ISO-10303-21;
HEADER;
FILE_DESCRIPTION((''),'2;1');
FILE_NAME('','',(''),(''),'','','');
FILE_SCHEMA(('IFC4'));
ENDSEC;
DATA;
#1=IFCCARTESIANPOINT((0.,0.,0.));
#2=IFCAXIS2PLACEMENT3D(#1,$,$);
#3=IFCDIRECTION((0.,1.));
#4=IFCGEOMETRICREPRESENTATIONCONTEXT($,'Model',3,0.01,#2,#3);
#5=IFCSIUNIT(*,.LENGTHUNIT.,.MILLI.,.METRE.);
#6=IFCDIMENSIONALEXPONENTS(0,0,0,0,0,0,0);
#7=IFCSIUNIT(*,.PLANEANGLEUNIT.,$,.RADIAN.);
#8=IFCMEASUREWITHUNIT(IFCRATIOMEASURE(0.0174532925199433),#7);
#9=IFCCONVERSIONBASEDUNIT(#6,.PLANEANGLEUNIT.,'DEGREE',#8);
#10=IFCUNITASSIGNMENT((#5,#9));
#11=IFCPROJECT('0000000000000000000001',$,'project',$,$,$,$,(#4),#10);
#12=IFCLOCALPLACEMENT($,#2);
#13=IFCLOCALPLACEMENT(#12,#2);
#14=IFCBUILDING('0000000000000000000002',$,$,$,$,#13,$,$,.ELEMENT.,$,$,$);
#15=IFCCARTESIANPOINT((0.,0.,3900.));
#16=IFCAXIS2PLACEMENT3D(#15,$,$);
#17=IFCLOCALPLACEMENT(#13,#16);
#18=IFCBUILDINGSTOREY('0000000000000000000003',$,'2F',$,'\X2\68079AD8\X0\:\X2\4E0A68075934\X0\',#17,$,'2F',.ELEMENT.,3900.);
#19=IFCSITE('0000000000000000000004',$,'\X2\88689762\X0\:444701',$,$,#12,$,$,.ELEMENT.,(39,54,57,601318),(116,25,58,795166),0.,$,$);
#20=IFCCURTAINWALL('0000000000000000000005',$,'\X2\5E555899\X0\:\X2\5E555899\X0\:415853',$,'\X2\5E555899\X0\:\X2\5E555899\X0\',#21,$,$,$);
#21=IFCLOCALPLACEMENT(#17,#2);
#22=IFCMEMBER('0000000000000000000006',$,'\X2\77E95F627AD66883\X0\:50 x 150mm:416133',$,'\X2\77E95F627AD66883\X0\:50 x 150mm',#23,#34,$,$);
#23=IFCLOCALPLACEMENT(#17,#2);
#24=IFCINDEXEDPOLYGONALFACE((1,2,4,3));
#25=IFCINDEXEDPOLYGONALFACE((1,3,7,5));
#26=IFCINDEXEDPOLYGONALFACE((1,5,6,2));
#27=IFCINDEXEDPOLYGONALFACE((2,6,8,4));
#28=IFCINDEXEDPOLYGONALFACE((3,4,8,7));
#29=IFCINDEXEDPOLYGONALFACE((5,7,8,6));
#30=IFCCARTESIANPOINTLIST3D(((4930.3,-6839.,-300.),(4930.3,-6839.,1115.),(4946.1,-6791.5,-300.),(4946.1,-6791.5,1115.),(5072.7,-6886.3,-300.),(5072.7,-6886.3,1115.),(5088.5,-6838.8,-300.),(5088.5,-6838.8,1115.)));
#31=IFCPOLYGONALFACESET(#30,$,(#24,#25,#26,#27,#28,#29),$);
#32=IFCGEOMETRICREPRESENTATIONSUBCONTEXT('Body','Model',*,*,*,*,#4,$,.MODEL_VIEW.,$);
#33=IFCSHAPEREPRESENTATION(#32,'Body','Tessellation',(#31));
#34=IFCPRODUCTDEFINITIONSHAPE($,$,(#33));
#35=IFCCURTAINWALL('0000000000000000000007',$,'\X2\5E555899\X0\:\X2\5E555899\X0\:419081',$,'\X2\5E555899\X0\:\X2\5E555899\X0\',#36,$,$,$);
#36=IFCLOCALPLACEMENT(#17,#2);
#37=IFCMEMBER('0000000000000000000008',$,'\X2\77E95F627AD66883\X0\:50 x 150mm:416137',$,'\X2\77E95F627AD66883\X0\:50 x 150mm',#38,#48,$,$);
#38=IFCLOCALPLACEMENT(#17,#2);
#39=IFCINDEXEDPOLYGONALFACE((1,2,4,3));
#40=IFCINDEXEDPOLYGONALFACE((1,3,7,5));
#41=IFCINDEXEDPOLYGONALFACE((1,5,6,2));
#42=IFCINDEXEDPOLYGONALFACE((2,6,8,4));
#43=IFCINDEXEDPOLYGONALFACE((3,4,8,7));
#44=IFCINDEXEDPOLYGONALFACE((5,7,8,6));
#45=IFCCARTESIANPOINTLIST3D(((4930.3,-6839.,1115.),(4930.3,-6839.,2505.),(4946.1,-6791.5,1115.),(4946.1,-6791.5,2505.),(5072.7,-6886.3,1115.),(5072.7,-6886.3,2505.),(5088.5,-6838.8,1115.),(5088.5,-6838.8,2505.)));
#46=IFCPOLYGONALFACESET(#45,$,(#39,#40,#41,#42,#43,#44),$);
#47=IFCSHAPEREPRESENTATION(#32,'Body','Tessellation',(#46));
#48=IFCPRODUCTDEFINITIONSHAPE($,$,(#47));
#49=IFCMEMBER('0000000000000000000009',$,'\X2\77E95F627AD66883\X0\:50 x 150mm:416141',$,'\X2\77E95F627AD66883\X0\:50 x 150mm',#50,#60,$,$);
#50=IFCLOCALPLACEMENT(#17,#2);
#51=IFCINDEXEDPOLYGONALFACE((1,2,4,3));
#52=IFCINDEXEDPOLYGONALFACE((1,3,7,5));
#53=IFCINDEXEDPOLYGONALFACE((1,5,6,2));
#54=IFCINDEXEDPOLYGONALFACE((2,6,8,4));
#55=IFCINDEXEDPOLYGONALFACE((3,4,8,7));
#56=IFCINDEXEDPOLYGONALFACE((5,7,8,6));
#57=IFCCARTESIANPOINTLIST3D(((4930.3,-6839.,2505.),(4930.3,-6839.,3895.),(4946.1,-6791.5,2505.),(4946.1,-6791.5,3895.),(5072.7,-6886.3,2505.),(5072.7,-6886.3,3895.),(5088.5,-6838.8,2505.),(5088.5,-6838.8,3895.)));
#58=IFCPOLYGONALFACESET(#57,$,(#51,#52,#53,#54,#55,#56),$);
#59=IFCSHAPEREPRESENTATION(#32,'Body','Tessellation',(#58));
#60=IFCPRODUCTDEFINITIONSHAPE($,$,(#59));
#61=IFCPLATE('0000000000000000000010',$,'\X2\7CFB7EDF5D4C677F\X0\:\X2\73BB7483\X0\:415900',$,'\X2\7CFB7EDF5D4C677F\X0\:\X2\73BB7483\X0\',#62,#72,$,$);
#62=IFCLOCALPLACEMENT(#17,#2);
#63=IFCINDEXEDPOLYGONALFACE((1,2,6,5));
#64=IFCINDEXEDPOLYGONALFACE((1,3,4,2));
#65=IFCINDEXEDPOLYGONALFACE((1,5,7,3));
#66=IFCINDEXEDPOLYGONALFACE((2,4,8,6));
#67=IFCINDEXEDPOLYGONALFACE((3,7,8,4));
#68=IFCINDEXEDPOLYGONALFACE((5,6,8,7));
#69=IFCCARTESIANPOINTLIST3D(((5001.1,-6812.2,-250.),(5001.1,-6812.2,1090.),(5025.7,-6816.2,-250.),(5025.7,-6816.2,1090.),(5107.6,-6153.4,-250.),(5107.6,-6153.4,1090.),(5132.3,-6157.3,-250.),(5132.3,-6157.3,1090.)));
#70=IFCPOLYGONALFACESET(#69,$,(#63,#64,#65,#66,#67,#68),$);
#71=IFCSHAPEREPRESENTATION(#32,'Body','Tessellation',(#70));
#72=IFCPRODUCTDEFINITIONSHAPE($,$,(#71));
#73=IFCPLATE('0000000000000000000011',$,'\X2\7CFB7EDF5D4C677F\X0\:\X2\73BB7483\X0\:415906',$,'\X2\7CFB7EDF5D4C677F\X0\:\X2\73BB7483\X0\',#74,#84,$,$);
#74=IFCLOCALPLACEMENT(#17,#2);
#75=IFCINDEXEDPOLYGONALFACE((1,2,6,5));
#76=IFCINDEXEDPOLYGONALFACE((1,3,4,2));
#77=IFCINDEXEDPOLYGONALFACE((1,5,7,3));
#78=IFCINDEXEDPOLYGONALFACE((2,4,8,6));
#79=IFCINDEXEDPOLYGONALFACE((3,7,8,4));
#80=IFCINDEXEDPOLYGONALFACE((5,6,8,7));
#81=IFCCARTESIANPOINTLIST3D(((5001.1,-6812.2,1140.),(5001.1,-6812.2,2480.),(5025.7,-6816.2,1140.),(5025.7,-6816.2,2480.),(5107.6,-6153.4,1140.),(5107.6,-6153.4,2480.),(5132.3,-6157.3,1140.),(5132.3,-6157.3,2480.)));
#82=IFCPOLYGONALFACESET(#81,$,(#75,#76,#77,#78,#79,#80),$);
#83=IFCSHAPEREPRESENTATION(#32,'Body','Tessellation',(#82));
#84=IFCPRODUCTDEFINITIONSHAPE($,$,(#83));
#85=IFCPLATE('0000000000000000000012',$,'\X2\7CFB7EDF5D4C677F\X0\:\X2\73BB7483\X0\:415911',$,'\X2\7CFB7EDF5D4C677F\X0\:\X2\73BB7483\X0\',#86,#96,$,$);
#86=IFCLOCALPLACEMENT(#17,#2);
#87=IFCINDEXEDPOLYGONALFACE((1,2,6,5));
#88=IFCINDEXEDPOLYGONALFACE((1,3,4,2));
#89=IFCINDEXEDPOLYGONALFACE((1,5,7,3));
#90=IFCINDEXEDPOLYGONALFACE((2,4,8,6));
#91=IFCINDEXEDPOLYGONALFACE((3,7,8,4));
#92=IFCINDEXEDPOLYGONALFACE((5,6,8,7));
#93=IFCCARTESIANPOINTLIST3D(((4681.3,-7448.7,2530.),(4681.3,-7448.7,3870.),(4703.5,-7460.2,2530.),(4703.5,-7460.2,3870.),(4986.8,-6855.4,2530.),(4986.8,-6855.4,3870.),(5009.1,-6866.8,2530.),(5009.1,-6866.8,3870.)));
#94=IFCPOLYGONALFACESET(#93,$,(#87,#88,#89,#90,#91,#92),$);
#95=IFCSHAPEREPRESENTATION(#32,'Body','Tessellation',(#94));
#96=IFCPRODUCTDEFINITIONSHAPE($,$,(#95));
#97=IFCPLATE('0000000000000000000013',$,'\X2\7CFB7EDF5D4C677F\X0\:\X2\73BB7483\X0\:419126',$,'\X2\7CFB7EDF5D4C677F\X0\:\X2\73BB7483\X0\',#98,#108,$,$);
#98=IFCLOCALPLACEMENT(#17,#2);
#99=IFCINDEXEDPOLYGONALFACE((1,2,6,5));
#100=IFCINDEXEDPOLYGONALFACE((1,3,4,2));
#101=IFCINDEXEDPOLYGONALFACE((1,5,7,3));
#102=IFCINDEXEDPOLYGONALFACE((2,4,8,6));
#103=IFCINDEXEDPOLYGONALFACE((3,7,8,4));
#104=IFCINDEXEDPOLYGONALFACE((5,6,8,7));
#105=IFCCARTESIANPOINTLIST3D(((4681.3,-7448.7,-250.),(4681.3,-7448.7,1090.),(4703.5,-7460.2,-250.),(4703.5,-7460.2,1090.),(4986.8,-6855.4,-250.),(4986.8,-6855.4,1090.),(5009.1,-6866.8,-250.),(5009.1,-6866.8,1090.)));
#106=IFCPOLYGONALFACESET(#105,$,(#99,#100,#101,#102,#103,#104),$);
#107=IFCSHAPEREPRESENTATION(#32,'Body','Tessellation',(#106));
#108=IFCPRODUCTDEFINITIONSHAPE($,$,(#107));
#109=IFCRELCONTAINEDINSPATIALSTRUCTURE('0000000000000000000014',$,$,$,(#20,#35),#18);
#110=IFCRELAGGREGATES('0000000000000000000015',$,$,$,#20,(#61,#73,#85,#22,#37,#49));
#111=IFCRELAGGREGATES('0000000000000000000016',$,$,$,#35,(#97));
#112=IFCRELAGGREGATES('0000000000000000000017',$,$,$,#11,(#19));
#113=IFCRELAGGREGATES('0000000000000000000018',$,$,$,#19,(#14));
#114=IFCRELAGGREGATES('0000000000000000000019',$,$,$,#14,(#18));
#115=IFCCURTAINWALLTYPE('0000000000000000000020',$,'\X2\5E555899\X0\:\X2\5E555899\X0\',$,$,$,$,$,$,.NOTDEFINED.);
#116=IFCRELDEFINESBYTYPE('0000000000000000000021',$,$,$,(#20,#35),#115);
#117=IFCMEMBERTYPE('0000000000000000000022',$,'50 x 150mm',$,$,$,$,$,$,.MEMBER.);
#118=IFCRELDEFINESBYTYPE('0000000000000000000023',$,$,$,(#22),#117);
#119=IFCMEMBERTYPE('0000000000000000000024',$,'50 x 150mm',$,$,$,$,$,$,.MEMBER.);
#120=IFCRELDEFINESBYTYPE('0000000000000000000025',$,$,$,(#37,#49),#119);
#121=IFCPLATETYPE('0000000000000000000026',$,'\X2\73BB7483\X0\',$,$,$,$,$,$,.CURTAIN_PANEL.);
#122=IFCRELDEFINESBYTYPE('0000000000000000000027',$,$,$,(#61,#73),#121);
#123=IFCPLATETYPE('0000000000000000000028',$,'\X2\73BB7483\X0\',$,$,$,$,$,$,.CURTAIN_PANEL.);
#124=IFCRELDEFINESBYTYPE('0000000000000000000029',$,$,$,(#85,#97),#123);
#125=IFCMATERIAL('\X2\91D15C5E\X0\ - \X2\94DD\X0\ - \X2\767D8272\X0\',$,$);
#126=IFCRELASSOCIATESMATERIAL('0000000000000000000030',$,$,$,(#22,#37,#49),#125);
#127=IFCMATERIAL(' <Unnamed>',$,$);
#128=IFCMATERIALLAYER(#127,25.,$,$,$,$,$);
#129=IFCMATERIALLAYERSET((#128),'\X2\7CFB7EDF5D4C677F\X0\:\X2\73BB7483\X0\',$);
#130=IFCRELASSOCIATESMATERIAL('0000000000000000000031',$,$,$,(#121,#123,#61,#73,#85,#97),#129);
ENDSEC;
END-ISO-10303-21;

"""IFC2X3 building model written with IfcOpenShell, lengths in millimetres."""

from ifc_helpers import new_model, entity, si_unit, converted_unit, direction, frame, frame_2d, origin, origin_2d_with_axis, place, context, subcontext, project, spatial, rectangle, extrude, source, transform, mapped, material, layer, layer_set, layer_usage, type_object, type_shapes, element, aggregate, save


model = new_model("IFC2X3")

# Units and contexts
model_context = context("Model", 3, precision=0.01, world=origin(), true_north=direction((0.0, 1.0)))
body_context = subcontext(model_context, "Body", "Model", "MODEL_VIEW")
ifc_project = project(units=[si_unit("LENGTHUNIT", "METRE", prefix="MILLI"), converted_unit("PLANEANGLEUNIT", "DEGREE", entity("IfcRatioMeasure", 0.0174532925199433), si_unit("PLANEANGLEUNIT", "RADIAN"), dimensions=[0, 0, 0, 0, 0, 0, 0])], contexts=[model_context])

# Site, building, storey
site_placement = place(None, origin())
site = spatial("IfcSite", under=ifc_project, at=site_placement, Name="表面:444701", CompositionType="ELEMENT", RefLatitude=(39, 54, 57, 601318), RefLongitude=(116, 25, 58, 795166), RefElevation=0.0)
building_placement = place(site_placement, origin())
building = spatial("IfcBuilding", under=site, at=building_placement, CompositionType="ELEMENT")
storey_placement = place(building_placement, frame((0.0, 0.0, 3900.0)))
storey = spatial("IfcBuildingStorey", under=building, at=storey_placement, Name="2F", ObjectType="标高:上标头", LongName="2F", CompositionType="ELEMENT", Elevation=3900.0)

# Curtain walls, member
curtain_wall_type = type_object("IfcCurtainWallType", Name="幕墙:幕墙", PredefinedType="NOTDEFINED")
curtain_wall_1_placement = place(storey_placement, frame((0.0, 0.0, -3900.0)))
curtain_wall_1 = element("IfcCurtainWall", 1, at=curtain_wall_1_placement, inside=storey, type_object=curtain_wall_type, Name="幕墙:幕墙:415853", ObjectType="幕墙:幕墙")
ifc_material_1 = material(Name="金属 - 铝 - 白色")
member_type_1 = type_object("IfcMemberType", Name="50 x 150mm", PredefinedType="MEMBER")
shared_shape_1 = source(origin(), body_context, "Body", "SweptSolid", [
    extrude(rectangle(XDim=150.0, YDim=50.0, at=origin_2d_with_axis()), frame((0.0, 0.0, -1415.0), z_axis=(0.0, 0.0, 1.0), x_axis=(0.0, -1.0, 0.0)), (0.0, 0.0, 1.0), 1415.0),
])
type_shapes(member_type_1, [shared_shape_1])
member_1_placement = place(storey_placement, frame((5009.4, -6838.9, -300.0), z_axis=(0.0, 0.0, -1.0), x_axis=(0.315223, 0.949018, 0.0)))
member_1 = element("IfcMember", 2, at=member_1_placement, type_object=member_type_1, material=ifc_material_1, Name="矩形竖梃:50 x 150mm:416133", ObjectType="矩形竖梃:50 x 150mm", context=body_context, shape_type="MappedRepresentation", body=[
    mapped(shared_shape_1, transform((0.0, 0.0, 0.0), scale=1.0)),
])
curtain_wall_2_placement = place(storey_placement, frame((0.0, 0.0, -3900.0)))
curtain_wall_2 = element("IfcCurtainWall", 3, at=curtain_wall_2_placement, inside=storey, type_object=curtain_wall_type, Name="幕墙:幕墙:419081", ObjectType="幕墙:幕墙")

# Members
member_type_2 = type_object("IfcMemberType", Name="50 x 150mm", PredefinedType="MEMBER")
shared_shape_2 = source(origin(), body_context, "Body", "SweptSolid", [
    extrude(rectangle(XDim=150.0, YDim=50.0, at=origin_2d_with_axis()), frame((0.0, 0.0, -1390.0), z_axis=(0.0, 0.0, 1.0), x_axis=(0.0, -1.0, 0.0)), (0.0, 0.0, 1.0), 1390.0),
])
type_shapes(member_type_2, [shared_shape_2])
member_2_placement = place(storey_placement, frame((5009.4, -6838.9, 1115.0), z_axis=(0.0, 0.0, -1.0), x_axis=(0.315223, 0.949018, 0.0)))
member_2 = element("IfcMember", 4, at=member_2_placement, type_object=member_type_2, material=ifc_material_1, Name="矩形竖梃:50 x 150mm:416137", ObjectType="矩形竖梃:50 x 150mm", context=body_context, shape_type="MappedRepresentation", body=[
    mapped(shared_shape_2, transform((0.0, 0.0, 0.0), scale=1.0)),
])
member_3_placement = place(storey_placement, frame((5009.4, -6838.9, 2505.0), z_axis=(0.0, 0.0, -1.0), x_axis=(0.315223, 0.949018, 0.0)))
member_3 = element("IfcMember", 5, at=member_3_placement, type_object=member_type_2, material=ifc_material_1, Name="矩形竖梃:50 x 150mm:416141", ObjectType="矩形竖梃:50 x 150mm", context=body_context, shape_type="MappedRepresentation", body=[
    mapped(shared_shape_2, transform((0.0, 0.0, 0.0), scale=1.0)),
])

# Plates
ifc_material_2 = material(Name=" <Unnamed>")
ifc_layer = layer(ifc_material_2, 25.0)
ifc_layer_set = layer_set([ifc_layer], Name="系统嵌板:玻璃")
ifc_layer_usage_1 = layer_usage(ifc_layer_set, "AXIS3", "POSITIVE", 0.0)
plate_type_1 = type_object("IfcPlateType", Name="玻璃", PredefinedType="CURTAIN_PANEL", material=ifc_layer_set)
shared_shape_3 = source(origin(), body_context, "Body", "SweptSolid", [
    extrude(rectangle(XDim=25.0, YDim=667.4, at=frame_2d((0.0, 0.0), x_axis=(1.0, 0.0))), frame((0.0, 0.0, 0.0), z_axis=(0.0, 0.0, 1.0), x_axis=(0.0, 1.0, 0.0)), (0.0, 0.0, 1.0), 1340.0),
])
type_shapes(plate_type_1, [shared_shape_3])
plate_1_placement = place(curtain_wall_1_placement, frame((5066.7, -6484.8, 3650.0), z_axis=(0.0, 0.0, 1.0), x_axis=(0.15966, 0.987172, 0.0)))
plate_1 = element("IfcPlate", 6, at=plate_1_placement, type_object=plate_type_1, material=ifc_layer_usage_1, Name="系统嵌板:玻璃:415900", ObjectType="系统嵌板:玻璃", context=body_context, shape_type="MappedRepresentation", body=[
    mapped(shared_shape_3, transform((0.0, 0.0, 0.0), scale=1.0)),
])
ifc_layer_usage_2 = layer_usage(ifc_layer_set, "AXIS3", "POSITIVE", 0.0)
plate_2_placement = place(curtain_wall_1_placement, frame((5066.7, -6484.8, 5040.0), z_axis=(0.0, 0.0, 1.0), x_axis=(0.15966, 0.987172, 0.0)))
plate_2 = element("IfcPlate", 7, at=plate_2_placement, type_object=plate_type_1, material=ifc_layer_usage_2, Name="系统嵌板:玻璃:415906", ObjectType="系统嵌板:玻璃", context=body_context, shape_type="MappedRepresentation", body=[
    mapped(shared_shape_3, transform((0.0, 0.0, 0.0), scale=1.0)),
])
ifc_layer_usage_3 = layer_usage(ifc_layer_set, "AXIS3", "POSITIVE", 0.0)
plate_type_2 = type_object("IfcPlateType", Name="玻璃", PredefinedType="CURTAIN_PANEL", material=ifc_layer_set)
shared_shape_4 = source(origin(), body_context, "Body", "SweptSolid", [
    extrude(rectangle(XDim=25.0, YDim=667.4, at=frame_2d((0.0, 0.0), x_axis=(1.0, 0.0))), frame((0.0, 0.0, 0.0), z_axis=(0.0, 0.0, 1.0), x_axis=(0.0, 1.0, 0.0)), (0.0, 0.0, 1.0), 1340.0),
])
type_shapes(plate_type_2, [shared_shape_4])
plate_3_placement = place(curtain_wall_1_placement, frame((4845.2, -7157.8, 6430.0), z_axis=(0.0, 0.0, 1.0), x_axis=(0.457867, 0.889021, 0.0)))
plate_3 = element("IfcPlate", 8, at=plate_3_placement, type_object=plate_type_2, material=ifc_layer_usage_3, Name="系统嵌板:玻璃:415911", ObjectType="系统嵌板:玻璃", context=body_context, shape_type="MappedRepresentation", body=[
    mapped(shared_shape_4, transform((0.0, 0.0, 0.0), scale=1.0)),
])
aggregate(curtain_wall_1, [plate_1, plate_2, plate_3, member_1, member_2, member_3])
ifc_layer_usage_4 = layer_usage(ifc_layer_set, "AXIS3", "POSITIVE", 0.0)
plate_4_placement = place(curtain_wall_2_placement, frame((4845.2, -7157.8, 3650.0), z_axis=(0.0, 0.0, 1.0), x_axis=(0.457867, 0.889021, 0.0)))
plate_4 = element("IfcPlate", 9, at=plate_4_placement, type_object=plate_type_2, material=ifc_layer_usage_4, Name="系统嵌板:玻璃:419126", ObjectType="系统嵌板:玻璃", context=body_context, shape_type="MappedRepresentation", body=[
    mapped(shared_shape_4, transform((0.0, 0.0, 0.0), scale=1.0)),
])
aggregate(curtain_wall_2, [plate_4])

save(model, "model.ifc")
